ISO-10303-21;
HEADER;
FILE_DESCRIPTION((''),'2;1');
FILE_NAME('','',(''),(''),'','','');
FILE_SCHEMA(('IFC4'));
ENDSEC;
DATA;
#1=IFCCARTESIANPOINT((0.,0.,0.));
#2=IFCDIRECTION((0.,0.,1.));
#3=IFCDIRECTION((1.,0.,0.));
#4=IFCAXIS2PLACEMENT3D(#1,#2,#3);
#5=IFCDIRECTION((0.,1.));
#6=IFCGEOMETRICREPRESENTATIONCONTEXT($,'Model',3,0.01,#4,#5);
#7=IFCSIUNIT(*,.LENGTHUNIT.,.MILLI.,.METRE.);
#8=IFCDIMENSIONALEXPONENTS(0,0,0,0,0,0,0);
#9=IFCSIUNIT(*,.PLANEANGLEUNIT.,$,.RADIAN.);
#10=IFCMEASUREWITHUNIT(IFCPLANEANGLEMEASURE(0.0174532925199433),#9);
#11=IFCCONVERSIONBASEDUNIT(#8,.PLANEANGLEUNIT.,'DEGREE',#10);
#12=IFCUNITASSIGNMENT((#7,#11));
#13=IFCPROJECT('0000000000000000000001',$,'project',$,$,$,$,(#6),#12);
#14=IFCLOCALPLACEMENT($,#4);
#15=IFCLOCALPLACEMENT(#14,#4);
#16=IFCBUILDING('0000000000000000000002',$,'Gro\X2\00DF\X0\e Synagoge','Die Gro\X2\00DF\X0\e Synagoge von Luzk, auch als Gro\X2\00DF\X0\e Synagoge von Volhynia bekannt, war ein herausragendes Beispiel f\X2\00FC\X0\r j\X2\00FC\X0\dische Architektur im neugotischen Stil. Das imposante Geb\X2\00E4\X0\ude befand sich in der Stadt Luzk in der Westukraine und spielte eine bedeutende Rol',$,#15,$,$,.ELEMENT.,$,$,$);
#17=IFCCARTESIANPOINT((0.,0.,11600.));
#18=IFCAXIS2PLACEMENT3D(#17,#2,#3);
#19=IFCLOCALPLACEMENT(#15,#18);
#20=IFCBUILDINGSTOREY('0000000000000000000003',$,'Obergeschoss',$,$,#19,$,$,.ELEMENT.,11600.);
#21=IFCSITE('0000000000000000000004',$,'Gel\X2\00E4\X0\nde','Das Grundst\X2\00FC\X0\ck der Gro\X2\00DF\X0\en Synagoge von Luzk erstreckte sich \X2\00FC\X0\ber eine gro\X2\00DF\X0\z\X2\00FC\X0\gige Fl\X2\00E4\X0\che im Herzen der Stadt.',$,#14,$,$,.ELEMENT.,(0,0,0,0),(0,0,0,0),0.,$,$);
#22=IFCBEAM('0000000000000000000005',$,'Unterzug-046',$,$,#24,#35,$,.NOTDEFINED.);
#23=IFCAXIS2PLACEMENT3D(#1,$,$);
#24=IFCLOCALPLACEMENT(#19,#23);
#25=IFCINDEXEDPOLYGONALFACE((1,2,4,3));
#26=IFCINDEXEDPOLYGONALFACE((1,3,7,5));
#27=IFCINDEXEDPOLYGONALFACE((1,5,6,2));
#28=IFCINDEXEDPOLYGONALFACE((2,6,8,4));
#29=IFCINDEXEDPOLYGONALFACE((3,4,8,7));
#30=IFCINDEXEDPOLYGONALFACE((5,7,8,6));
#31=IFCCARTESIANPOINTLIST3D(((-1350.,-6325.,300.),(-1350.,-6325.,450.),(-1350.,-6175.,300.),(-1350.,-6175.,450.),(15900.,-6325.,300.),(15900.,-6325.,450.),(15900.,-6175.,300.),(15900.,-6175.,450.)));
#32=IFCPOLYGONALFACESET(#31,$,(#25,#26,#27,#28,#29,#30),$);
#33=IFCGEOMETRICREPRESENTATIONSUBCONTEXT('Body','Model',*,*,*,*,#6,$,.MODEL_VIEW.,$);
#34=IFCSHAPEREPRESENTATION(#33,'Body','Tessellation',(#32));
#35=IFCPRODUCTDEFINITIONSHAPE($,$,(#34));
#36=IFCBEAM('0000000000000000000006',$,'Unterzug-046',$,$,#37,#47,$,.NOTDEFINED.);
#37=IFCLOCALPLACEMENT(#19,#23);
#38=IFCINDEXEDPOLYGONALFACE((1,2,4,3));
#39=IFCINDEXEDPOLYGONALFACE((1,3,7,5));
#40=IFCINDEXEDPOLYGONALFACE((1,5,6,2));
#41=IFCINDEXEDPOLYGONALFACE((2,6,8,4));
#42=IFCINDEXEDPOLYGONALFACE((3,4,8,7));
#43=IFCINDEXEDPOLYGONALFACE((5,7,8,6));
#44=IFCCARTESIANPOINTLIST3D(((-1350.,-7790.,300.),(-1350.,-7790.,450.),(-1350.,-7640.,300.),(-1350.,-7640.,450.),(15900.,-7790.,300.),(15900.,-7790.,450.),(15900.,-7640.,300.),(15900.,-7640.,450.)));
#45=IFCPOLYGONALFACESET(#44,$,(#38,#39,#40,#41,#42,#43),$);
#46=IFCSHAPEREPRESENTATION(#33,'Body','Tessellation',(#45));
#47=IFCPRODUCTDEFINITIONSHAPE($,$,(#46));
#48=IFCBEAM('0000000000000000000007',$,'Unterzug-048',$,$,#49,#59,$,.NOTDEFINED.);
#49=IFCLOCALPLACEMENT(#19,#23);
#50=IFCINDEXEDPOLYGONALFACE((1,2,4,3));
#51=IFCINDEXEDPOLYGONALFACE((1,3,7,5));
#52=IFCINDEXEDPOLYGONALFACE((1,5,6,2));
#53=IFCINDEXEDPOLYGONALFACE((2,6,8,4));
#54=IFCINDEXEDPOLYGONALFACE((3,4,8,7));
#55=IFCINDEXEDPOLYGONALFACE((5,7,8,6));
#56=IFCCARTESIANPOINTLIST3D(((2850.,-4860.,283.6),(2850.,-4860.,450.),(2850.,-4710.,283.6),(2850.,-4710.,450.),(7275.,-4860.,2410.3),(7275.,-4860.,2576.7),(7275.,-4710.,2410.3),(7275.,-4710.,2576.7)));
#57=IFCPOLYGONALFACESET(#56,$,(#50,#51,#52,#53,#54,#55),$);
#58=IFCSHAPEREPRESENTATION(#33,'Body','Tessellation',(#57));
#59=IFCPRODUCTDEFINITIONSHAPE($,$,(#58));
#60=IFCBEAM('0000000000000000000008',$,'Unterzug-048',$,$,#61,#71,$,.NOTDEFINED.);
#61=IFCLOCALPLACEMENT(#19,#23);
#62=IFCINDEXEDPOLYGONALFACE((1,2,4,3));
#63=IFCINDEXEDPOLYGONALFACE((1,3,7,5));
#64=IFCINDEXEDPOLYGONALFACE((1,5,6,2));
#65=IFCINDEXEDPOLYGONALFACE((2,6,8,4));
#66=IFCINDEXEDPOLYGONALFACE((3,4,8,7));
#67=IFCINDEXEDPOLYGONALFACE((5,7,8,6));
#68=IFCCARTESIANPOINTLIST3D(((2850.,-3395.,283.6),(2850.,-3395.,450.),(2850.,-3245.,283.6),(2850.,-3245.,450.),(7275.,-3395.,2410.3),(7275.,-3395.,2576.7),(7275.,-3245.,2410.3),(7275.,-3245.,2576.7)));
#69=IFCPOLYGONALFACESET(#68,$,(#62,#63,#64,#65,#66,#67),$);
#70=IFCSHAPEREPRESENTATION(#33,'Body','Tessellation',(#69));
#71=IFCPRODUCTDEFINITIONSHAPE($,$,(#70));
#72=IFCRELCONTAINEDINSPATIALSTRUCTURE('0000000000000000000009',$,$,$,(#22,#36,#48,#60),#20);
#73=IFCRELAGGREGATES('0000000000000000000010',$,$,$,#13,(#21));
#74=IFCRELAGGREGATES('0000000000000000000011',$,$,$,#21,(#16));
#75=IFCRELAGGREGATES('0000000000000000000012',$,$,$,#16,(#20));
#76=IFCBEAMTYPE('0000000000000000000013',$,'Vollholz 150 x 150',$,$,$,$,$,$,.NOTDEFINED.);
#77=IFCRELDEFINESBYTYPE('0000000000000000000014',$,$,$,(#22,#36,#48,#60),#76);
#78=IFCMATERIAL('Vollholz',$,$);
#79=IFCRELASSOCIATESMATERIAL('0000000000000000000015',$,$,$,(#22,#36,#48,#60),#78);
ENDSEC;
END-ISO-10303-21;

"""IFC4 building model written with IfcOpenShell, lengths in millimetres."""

from ifc_helpers import new_model, entity, si_unit, converted_unit, direction, frame, frame_2d, origin_with_axes, place, context, subcontext, project, spatial, rectangle, extrude, clip, halfspace, material, type_object, element, save


model = new_model("IFC4")

# Units and contexts
model_context = context("Model", 3, precision=0.01, world=origin_with_axes(), true_north=direction((0.0, 1.0)))
body_context = subcontext(model_context, "Body", "Model", "MODEL_VIEW")
ifc_project = project(units=[si_unit("LENGTHUNIT", "METRE", prefix="MILLI"), converted_unit("PLANEANGLEUNIT", "DEGREE", entity("IfcPlaneAngleMeasure", 0.0174532925199433), si_unit("PLANEANGLEUNIT", "RADIAN"), dimensions=[0, 0, 0, 0, 0, 0, 0])], contexts=[model_context])

# Site, building, storey
site_placement = place(None, origin_with_axes())
site = spatial("IfcSite", under=ifc_project, at=site_placement, Name="Gelände", Description="Das Grundstück der Großen Synagoge von Luzk erstreckte sich über eine großzügige Fläche im Herzen der Stadt.", CompositionType="ELEMENT", RefLatitude=(0, 0, 0, 0), RefLongitude=(0, 0, 0, 0), RefElevation=0.0)
building_placement = place(site_placement, origin_with_axes())
building = spatial("IfcBuilding", under=site, at=building_placement, Name="Große Synagoge", Description="Die Große Synagoge von Luzk, auch als Große Synagoge von Volhynia bekannt, war ein herausragendes Beispiel für jüdische Architektur im neugotischen Stil. Das imposante Gebäude befand sich in der Stadt Luzk in der Westukraine und spielte eine bedeutende Rol", CompositionType="ELEMENT")
storey_placement = place(building_placement, frame((0.0, 0.0, 11600.0), z_axis=(0.0, 0.0, 1.0), x_axis=(1.0, 0.0, 0.0)))
storey = spatial("IfcBuildingStorey", under=building, at=storey_placement, Name="Obergeschoss", CompositionType="ELEMENT", Elevation=11600.0)

# Shared definitions
ifc_material = material(Name="Vollholz")

# Beams
beam_type_1 = type_object("IfcBeamType", Name="Vollholz 150 x 150", PredefinedType="NOTDEFINED")
for number, where, z_axis, x_axis, name in (
    (1, (15900.0, -6250.0, 450.0), (0.0, 0.0, 1.0), (0.0, 1.0, 0.0), "Unterzug-046"),
    (2, (15900.0, -7715.0, 450.0), (0.0, 0.0, 1.0), (0.0, 1.0, 0.0), "Unterzug-046"),
):
    element("IfcBeam", number, at=place(storey_placement, frame(where, z_axis=z_axis, x_axis=x_axis)), inside=storey, type_object=beam_type_1, material=ifc_material, Name=name, PredefinedType="NOTDEFINED", context=body_context, shape_type="SweptSolid", body=[
        extrude(rectangle(XDim=150.0, YDim=150.0, at=frame_2d((-75.0, 0.0), x_axis=(1.0, 0.0))), frame((0.0, 0.0, 0.0), z_axis=(0.0, 1.0, 0.0), x_axis=(0.0, 0.0, 1.0)), (0.0, 0.0, 1.0), 17250.0),
    ])
for number, where, z_axis, x_axis, name in (
    (3, (7275.0, -4785.0, 2576.7), (0.0, 0.0, 1.0), (0.0, 1.0, 0.0), "Unterzug-048"),
    (4, (7275.0, -3320.0, 2576.7), (0.0, 0.0, 1.0), (0.0, 1.0, 0.0), "Unterzug-048"),
):
    element("IfcBeam", number, at=place(storey_placement, frame(where, z_axis=z_axis, x_axis=x_axis)), inside=storey, type_object=beam_type_1, material=ifc_material, Name=name, PredefinedType="NOTDEFINED", context=body_context, shape_type="Clipping", body=[
        clip(clip(extrude(rectangle(XDim=150.0, YDim=150.0, at=frame_2d((-75.0, 0.0), x_axis=(1.0, 0.0))), frame((0.0, -91.9, 44.2), z_axis=(0.0, 0.901307, -0.433181), x_axis=(0.0, 0.433181, 0.901307)), (0.0, 0.0, 1.0), 5113.4), halfspace(frame((0.0, 0.0, 0.0), z_axis=(0.0, 1.0, 0.0), x_axis=(0.0, 0.0, 1.0)), True)), halfspace(frame((0.0, 4425.0, 0.0), z_axis=(0.0, -1.0, 0.0), x_axis=(0.0, 0.0, -1.0)), True)),
    ])

save(model, "model.ifc")
